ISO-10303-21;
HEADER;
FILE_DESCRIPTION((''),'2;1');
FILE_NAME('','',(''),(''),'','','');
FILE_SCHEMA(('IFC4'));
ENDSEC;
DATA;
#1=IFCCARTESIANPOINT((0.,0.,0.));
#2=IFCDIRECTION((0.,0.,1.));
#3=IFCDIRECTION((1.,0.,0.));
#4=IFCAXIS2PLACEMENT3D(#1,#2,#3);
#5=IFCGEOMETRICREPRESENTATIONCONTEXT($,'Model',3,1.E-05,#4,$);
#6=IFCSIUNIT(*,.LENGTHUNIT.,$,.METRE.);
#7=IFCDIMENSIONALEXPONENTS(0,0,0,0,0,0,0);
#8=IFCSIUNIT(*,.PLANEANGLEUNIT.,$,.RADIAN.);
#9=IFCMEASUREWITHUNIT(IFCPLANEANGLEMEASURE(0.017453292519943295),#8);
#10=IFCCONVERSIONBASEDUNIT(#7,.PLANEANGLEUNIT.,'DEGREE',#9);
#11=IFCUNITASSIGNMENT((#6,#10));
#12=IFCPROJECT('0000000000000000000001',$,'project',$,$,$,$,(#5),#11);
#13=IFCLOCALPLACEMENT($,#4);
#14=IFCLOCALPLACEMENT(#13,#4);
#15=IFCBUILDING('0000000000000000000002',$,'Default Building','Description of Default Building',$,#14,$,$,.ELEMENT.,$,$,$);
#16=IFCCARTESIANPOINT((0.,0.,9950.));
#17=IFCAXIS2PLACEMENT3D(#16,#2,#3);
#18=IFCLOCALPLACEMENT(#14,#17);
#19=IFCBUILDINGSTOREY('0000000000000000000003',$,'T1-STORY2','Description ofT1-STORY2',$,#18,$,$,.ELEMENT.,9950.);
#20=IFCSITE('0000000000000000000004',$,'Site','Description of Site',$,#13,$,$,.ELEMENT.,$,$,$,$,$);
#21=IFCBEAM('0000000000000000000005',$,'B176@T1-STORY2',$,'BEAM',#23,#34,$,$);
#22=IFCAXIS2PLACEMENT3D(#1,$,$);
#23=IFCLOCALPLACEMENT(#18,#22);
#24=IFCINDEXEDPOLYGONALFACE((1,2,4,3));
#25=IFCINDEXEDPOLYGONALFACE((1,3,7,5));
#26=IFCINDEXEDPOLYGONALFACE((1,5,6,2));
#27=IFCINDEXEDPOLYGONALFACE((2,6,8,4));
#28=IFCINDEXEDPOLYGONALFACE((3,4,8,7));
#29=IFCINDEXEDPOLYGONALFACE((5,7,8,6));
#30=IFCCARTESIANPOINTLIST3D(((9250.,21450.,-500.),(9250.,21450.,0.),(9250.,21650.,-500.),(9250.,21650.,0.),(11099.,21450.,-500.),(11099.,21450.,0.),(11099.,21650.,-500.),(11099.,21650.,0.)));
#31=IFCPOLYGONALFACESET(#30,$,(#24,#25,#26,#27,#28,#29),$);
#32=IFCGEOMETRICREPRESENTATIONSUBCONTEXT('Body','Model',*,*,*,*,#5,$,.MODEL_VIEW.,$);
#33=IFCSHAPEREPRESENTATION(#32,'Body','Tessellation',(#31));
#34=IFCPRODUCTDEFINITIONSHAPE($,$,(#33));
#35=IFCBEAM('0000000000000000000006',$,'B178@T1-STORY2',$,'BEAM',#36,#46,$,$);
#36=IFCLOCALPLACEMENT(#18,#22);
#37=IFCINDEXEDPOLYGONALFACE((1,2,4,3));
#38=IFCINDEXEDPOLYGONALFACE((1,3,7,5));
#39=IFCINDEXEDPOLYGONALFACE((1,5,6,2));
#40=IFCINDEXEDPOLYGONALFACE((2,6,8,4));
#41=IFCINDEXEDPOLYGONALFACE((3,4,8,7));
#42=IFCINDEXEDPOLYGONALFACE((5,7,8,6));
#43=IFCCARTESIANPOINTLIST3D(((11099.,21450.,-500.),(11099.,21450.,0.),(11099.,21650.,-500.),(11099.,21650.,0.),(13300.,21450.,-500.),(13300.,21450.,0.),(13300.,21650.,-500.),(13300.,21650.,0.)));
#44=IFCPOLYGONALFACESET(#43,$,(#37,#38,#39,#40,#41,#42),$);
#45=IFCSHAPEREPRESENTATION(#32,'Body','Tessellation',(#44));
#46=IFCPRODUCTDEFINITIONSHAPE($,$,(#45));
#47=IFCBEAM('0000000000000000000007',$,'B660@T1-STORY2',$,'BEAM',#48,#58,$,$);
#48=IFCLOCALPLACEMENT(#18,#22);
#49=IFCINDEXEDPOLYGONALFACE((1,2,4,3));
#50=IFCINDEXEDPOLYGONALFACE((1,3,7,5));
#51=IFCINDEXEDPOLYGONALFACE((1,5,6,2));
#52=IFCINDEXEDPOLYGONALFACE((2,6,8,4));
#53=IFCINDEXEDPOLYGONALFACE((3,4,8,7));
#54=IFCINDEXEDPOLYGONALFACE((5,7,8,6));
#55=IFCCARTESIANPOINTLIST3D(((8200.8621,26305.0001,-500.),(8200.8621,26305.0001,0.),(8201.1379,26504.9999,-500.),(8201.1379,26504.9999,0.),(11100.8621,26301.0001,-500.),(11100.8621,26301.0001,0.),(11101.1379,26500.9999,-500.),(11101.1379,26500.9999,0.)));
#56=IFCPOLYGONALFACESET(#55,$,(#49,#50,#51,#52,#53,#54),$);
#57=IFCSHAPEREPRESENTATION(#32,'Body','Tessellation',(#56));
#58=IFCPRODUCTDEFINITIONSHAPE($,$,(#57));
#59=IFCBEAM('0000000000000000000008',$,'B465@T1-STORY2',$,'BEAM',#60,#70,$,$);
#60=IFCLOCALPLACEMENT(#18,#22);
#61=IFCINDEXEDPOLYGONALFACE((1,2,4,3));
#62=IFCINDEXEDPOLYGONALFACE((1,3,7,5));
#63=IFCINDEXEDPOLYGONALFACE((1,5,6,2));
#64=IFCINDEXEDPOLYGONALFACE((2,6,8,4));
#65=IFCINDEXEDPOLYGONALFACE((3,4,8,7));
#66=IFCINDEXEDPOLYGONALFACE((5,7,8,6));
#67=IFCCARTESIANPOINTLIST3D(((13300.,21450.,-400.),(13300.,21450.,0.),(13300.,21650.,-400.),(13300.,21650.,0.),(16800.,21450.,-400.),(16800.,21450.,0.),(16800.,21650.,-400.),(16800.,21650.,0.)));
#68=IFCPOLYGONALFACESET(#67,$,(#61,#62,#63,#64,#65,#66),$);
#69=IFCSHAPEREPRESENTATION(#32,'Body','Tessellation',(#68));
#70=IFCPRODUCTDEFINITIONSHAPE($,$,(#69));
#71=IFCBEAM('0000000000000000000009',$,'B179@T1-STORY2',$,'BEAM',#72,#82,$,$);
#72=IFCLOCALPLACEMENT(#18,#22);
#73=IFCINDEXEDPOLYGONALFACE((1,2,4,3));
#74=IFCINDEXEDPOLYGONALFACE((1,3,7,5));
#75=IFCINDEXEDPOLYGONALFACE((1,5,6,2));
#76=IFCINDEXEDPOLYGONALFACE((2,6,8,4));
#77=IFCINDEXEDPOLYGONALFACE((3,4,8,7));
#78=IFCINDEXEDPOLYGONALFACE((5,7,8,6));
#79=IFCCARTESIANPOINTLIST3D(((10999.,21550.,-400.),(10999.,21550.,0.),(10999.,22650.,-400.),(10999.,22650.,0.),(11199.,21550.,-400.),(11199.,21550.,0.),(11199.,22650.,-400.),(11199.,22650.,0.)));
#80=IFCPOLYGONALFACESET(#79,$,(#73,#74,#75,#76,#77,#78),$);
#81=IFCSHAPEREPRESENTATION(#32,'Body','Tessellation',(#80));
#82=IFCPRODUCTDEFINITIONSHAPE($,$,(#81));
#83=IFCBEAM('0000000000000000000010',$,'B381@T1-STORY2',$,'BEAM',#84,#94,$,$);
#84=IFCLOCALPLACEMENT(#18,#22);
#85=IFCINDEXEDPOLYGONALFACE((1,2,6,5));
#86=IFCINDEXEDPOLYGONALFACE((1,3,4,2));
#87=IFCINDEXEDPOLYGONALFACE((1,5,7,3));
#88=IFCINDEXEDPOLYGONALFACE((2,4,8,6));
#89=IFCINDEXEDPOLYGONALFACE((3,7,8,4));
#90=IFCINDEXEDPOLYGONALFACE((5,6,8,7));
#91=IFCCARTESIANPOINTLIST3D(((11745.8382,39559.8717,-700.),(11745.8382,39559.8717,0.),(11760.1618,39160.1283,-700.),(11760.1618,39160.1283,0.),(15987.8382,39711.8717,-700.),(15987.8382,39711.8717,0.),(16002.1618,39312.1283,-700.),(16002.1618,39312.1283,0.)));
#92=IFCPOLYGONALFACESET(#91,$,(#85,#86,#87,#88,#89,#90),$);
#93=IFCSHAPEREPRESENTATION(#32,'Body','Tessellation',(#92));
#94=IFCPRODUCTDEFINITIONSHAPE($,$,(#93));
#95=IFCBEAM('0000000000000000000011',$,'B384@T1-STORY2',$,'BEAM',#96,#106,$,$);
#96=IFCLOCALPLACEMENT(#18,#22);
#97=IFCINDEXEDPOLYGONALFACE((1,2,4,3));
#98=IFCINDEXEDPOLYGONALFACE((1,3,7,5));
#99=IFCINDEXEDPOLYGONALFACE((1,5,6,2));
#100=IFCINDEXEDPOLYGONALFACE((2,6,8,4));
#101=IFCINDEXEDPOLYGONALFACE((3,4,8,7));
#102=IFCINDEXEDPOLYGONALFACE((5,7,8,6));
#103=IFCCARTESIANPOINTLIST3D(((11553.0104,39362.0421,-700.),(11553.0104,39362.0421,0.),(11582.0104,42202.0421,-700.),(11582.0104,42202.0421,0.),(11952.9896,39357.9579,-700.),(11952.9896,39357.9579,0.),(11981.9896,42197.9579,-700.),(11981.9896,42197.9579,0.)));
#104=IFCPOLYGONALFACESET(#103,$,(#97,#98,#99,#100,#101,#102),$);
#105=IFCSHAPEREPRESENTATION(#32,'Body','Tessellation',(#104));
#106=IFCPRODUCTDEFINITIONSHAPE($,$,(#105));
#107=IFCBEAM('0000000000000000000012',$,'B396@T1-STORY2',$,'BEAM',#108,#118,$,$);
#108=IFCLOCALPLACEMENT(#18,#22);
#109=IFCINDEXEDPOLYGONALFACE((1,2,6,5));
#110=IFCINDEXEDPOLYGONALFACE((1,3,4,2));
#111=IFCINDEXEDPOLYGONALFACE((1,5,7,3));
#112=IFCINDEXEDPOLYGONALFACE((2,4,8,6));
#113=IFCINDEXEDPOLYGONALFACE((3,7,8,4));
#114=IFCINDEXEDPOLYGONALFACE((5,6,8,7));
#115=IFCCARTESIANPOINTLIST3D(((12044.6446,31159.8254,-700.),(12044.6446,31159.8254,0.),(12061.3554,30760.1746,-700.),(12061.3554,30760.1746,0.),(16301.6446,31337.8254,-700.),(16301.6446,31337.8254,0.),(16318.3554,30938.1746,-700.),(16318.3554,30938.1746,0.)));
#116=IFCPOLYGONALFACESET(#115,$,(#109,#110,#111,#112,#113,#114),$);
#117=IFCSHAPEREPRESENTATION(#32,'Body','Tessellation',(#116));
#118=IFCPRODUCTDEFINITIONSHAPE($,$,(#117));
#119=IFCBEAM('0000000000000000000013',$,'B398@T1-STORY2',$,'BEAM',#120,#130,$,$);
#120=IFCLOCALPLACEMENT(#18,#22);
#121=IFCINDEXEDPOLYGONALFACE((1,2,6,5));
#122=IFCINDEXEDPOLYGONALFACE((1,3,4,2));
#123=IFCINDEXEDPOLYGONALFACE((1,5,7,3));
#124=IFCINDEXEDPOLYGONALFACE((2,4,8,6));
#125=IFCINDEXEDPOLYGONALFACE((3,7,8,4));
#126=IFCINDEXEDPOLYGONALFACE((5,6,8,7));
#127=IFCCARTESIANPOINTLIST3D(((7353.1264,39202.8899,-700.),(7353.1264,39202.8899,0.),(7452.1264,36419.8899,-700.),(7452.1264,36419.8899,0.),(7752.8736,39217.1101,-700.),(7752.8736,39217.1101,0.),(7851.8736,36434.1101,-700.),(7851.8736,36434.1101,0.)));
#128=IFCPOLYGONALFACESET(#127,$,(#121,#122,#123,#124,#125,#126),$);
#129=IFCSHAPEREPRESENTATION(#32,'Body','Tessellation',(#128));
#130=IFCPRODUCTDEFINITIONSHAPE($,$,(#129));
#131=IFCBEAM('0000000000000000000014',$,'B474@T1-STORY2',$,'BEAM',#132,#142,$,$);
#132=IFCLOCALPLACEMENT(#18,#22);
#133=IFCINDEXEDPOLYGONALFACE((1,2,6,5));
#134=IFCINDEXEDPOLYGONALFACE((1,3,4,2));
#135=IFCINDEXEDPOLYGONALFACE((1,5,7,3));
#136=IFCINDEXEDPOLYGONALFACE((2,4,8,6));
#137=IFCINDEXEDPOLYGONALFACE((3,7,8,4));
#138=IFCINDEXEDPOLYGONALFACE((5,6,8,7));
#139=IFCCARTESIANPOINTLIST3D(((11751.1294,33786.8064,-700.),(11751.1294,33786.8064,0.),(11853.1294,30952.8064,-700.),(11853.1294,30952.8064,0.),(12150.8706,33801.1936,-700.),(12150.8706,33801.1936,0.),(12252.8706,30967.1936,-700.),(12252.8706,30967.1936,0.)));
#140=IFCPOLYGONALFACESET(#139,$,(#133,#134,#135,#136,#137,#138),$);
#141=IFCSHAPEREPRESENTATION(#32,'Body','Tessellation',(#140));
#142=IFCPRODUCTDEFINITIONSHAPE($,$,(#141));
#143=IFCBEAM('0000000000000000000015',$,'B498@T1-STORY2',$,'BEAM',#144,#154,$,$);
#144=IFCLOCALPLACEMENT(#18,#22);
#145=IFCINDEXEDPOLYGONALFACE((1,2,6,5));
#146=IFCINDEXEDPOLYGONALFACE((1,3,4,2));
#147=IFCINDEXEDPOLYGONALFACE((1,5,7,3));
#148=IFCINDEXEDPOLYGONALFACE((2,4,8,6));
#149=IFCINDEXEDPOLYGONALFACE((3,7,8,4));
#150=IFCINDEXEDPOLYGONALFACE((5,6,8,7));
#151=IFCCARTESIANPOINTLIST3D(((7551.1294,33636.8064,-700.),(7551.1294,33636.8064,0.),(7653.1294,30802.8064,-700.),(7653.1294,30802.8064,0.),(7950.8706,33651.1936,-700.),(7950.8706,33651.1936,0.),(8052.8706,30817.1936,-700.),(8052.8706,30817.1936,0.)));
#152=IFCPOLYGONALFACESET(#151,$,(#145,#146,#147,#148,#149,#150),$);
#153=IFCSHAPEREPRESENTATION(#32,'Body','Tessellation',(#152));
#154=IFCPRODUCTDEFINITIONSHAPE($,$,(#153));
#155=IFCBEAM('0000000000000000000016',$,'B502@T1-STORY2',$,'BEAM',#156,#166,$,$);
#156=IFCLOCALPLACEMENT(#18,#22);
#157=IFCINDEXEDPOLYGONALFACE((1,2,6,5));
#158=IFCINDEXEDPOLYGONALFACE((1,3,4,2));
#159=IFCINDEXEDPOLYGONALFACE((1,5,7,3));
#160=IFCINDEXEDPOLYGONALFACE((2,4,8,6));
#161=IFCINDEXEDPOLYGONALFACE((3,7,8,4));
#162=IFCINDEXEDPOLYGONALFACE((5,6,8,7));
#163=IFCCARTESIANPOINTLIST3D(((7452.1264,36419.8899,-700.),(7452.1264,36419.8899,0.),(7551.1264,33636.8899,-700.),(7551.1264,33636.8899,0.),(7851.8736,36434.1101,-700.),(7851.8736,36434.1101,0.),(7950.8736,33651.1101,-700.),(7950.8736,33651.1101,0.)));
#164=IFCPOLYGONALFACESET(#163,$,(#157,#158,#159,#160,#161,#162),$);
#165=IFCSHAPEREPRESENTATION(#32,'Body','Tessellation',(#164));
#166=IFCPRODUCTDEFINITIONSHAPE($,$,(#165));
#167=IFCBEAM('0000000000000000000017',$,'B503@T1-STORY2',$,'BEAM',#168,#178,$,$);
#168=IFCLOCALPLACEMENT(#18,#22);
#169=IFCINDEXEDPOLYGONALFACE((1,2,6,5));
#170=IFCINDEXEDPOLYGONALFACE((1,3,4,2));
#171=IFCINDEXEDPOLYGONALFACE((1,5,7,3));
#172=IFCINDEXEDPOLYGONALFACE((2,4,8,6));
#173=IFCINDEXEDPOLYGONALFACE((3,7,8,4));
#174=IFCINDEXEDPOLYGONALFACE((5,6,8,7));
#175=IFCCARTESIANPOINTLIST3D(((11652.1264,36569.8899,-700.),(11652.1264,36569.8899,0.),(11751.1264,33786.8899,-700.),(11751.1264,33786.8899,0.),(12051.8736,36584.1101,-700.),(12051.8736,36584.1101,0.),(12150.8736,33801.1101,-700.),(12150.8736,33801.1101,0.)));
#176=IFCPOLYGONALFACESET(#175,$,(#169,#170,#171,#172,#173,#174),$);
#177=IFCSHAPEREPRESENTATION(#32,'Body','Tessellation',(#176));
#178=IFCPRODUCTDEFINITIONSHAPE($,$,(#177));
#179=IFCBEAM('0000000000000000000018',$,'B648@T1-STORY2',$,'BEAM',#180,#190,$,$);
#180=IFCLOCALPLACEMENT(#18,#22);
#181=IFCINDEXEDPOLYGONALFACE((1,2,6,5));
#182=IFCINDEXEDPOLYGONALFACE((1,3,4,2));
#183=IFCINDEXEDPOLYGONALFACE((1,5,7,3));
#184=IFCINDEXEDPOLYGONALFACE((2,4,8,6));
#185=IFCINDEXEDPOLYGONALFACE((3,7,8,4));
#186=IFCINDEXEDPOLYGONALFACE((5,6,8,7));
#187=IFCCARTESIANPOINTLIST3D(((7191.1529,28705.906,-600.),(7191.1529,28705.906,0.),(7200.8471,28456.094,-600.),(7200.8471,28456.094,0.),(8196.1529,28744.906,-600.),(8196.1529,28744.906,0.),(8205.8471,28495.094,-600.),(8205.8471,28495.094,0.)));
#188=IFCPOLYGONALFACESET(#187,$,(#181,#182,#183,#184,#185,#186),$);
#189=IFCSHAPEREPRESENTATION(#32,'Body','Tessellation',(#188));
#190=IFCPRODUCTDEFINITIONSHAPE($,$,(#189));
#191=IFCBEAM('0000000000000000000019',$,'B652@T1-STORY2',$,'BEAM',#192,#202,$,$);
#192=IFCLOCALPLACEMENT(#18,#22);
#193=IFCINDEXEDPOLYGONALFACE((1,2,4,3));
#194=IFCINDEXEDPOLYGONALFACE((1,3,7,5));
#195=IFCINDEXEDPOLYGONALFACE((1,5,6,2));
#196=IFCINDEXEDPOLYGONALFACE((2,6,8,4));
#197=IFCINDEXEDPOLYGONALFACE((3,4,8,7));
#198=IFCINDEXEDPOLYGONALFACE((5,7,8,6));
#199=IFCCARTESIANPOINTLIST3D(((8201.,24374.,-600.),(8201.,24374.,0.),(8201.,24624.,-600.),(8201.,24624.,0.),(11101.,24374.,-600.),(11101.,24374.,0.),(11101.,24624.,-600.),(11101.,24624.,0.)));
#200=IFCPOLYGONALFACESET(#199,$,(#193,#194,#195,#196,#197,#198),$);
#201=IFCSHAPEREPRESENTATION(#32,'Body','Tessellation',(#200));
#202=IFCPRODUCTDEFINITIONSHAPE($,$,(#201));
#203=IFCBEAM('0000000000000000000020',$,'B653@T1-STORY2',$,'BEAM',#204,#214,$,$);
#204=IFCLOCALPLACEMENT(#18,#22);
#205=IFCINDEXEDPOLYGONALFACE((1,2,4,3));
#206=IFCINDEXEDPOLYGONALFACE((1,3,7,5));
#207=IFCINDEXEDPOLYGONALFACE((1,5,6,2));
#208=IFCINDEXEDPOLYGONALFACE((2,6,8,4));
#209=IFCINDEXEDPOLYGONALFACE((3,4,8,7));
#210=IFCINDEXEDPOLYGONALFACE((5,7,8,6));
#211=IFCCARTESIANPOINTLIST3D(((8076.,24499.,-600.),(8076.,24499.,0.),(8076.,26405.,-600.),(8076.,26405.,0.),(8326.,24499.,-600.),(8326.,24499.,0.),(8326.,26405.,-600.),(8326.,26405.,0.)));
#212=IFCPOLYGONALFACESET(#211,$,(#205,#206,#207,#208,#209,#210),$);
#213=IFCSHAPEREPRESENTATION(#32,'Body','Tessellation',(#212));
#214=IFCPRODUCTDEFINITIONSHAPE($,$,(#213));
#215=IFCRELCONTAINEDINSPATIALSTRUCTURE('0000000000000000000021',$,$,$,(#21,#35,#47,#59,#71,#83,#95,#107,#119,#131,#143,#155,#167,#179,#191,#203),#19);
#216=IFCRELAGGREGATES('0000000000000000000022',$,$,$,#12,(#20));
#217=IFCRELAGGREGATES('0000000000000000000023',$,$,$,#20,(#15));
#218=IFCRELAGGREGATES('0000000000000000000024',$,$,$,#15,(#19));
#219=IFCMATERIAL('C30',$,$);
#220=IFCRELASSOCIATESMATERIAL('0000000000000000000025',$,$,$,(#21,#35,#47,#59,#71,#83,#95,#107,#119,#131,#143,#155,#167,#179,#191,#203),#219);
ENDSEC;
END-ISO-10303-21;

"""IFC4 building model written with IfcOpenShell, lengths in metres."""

from ifc_helpers import new_model, entity, si_unit, converted_unit, frame, origin_with_axes, place, context, subcontext, project, spatial, rectangle, extrude, material, element, save


model = new_model("IFC4")

# Units and contexts
model_context = context("Model", 3, precision=1e-05, world=origin_with_axes())
body_context = subcontext(model_context, "Body", "Model", "MODEL_VIEW")
ifc_project = project(units=[si_unit("LENGTHUNIT", "METRE"), converted_unit("PLANEANGLEUNIT", "DEGREE", entity("IfcPlaneAngleMeasure", 0.017453292519943295), si_unit("PLANEANGLEUNIT", "RADIAN"), dimensions=[0, 0, 0, 0, 0, 0, 0])], contexts=[model_context])

# Site, building, storey
site_placement = place(None, origin_with_axes())
site = spatial("IfcSite", under=ifc_project, at=site_placement, Name="Site", Description="Description of Site", CompositionType="ELEMENT")
building_placement = place(site_placement, origin_with_axes())
building = spatial("IfcBuilding", under=site, at=building_placement, Name="Default Building", Description="Description of Default Building", CompositionType="ELEMENT")
storey_placement = place(building_placement, frame((0.0, 0.0, 9950.0), z_axis=(0.0, 0.0, 1.0), x_axis=(1.0, 0.0, 0.0)))
storey = spatial("IfcBuildingStorey", under=building, at=storey_placement, Name="T1-STORY2", Description="Description ofT1-STORY2", CompositionType="ELEMENT", Elevation=9950.0)

# Beams
ifc_material_1 = material(Name="C30")
beam_1_placement = place(storey_placement, frame((9250.0, 21550.0, -250.0), z_axis=(1.0, 0.0, 0.0), x_axis=(0.0, 1.0, 0.0)))
element("IfcBeam", 1, at=beam_1_placement, inside=storey, material=ifc_material_1, Name="B176@T1-STORY2", ObjectType="BEAM", context=body_context, shape_type="SweptSolid", body=[
    extrude(rectangle(XDim=200.0, YDim=500.0), origin_with_axes(), (0.0, 0.0, 1.0), 1849.0),
])
beam_2_placement = place(storey_placement, frame((11099.0, 21550.0, -250.0), z_axis=(1.0, 0.0, 0.0), x_axis=(0.0, 1.0, 0.0)))
element("IfcBeam", 2, at=beam_2_placement, inside=storey, material=ifc_material_1, Name="B178@T1-STORY2", ObjectType="BEAM", context=body_context, shape_type="SweptSolid", body=[
    extrude(rectangle(XDim=200.0, YDim=500.0), origin_with_axes(), (0.0, 0.0, 1.0), 2201.0),
])
beam_3_placement = place(storey_placement, frame((8201.0, 26405.0, -250.0), z_axis=(0.999999, -0.001379, 0.0), x_axis=(0.001379, 0.999999, 0.0)))
element("IfcBeam", 3, at=beam_3_placement, inside=storey, material=ifc_material_1, Name="B660@T1-STORY2", ObjectType="BEAM", context=body_context, shape_type="SweptSolid", body=[
    extrude(rectangle(XDim=200.0, YDim=500.0), origin_with_axes(), (0.0, 0.0, 1.0), 2900.0028),
])
beam_4_placement = place(storey_placement, frame((13300.0, 21550.0, -200.0), z_axis=(1.0, 0.0, 0.0), x_axis=(0.0, 1.0, 0.0)))
element("IfcBeam", 4, at=beam_4_placement, inside=storey, material=ifc_material_1, Name="B465@T1-STORY2", ObjectType="BEAM", context=body_context, shape_type="SweptSolid", body=[
    extrude(rectangle(XDim=200.0, YDim=400.0), origin_with_axes(), (0.0, 0.0, 1.0), 3500.0),
])
beam_5_placement = place(storey_placement, frame((11099.0, 21550.0, -200.0), z_axis=(0.0, 1.0, 0.0), x_axis=(-1.0, 0.0, 0.0)))
element("IfcBeam", 5, at=beam_5_placement, inside=storey, material=ifc_material_1, Name="B179@T1-STORY2", ObjectType="BEAM", context=body_context, shape_type="SweptSolid", body=[
    extrude(rectangle(XDim=200.0, YDim=400.0), origin_with_axes(), (0.0, 0.0, 1.0), 1100.0),
])
beam_6_placement = place(storey_placement, frame((11753.0, 39360.0, -350.0), z_axis=(0.999359, 0.035809, 0.0), x_axis=(-0.035809, 0.999359, 0.0)))
element("IfcBeam", 6, at=beam_6_placement, inside=storey, material=ifc_material_1, Name="B381@T1-STORY2", ObjectType="BEAM", context=body_context, shape_type="SweptSolid", body=[
    extrude(rectangle(XDim=400.0, YDim=700.0), origin_with_axes(), (0.0, 0.0, 1.0), 4244.7224),
])
beam_7_placement = place(storey_placement, frame((11753.0, 39360.0, -350.0), z_axis=(0.010211, 0.999948, 0.0), x_axis=(-0.999948, 0.010211, 0.0)))
element("IfcBeam", 7, at=beam_7_placement, inside=storey, material=ifc_material_1, Name="B384@T1-STORY2", ObjectType="BEAM", context=body_context, shape_type="SweptSolid", body=[
    extrude(rectangle(XDim=400.0, YDim=700.0), origin_with_axes(), (0.0, 0.0, 1.0), 2840.1481),
])
beam_8_placement = place(storey_placement, frame((12053.0, 30960.0, -350.0), z_axis=(0.999127, 0.041777, 0.0), x_axis=(-0.041777, 0.999127, 0.0)))
element("IfcBeam", 8, at=beam_8_placement, inside=storey, material=ifc_material_1, Name="B396@T1-STORY2", ObjectType="BEAM", context=body_context, shape_type="SweptSolid", body=[
    extrude(rectangle(XDim=400.0, YDim=700.0), origin_with_axes(), (0.0, 0.0, 1.0), 4260.7198),
])
beam_9_placement = place(storey_placement, frame((7553.0, 39210.0, -350.0), z_axis=(0.035551, -0.999368, 0.0), x_axis=(0.999368, 0.035551, 0.0)))
element("IfcBeam", 9, at=beam_9_placement, inside=storey, material=ifc_material_1, Name="B398@T1-STORY2", ObjectType="BEAM", context=body_context, shape_type="SweptSolid", body=[
    extrude(rectangle(XDim=400.0, YDim=700.0), origin_with_axes(), (0.0, 0.0, 1.0), 2784.7603),
])
for number, where, z_axis, x_axis, name in (
    (10, (11951.0, 33794.0, -350.0), (0.035968, -0.999353, 0.0), (0.999353, 0.035968, 0.0), "B474@T1-STORY2"),
    (11, (7751.0, 33644.0, -350.0), (0.035968, -0.999353, 0.0), (0.999353, 0.035968, 0.0), "B498@T1-STORY2"),
):
    element("IfcBeam", number, at=place(storey_placement, frame(where, z_axis=z_axis, x_axis=x_axis)), inside=storey, material=ifc_material_1, Name=name, ObjectType="BEAM", context=body_context, shape_type="SweptSolid", body=[
        extrude(rectangle(XDim=400.0, YDim=700.0), origin_with_axes(), (0.0, 0.0, 1.0), 2835.835),
    ])
for number, where, z_axis, x_axis, name in (
    (12, (7652.0, 36427.0, -350.0), (0.035551, -0.999368, 0.0), (0.999368, 0.035551, 0.0), "B502@T1-STORY2"),
    (13, (11852.0, 36577.0, -350.0), (0.035551, -0.999368, 0.0), (0.999368, 0.035551, 0.0), "B503@T1-STORY2"),
):
    element("IfcBeam", number, at=place(storey_placement, frame(where, z_axis=z_axis, x_axis=x_axis)), inside=storey, material=ifc_material_1, Name=name, ObjectType="BEAM", context=body_context, shape_type="SweptSolid", body=[
        extrude(rectangle(XDim=400.0, YDim=700.0), origin_with_axes(), (0.0, 0.0, 1.0), 2784.7603),
    ])
beam_10_placement = place(storey_placement, frame((7196.0, 28581.0, -300.0), z_axis=(0.999248, 0.038777, 0.0), x_axis=(-0.038777, 0.999248, 0.0)))
element("IfcBeam", 14, at=beam_10_placement, inside=storey, material=ifc_material_1, Name="B648@T1-STORY2", ObjectType="BEAM", context=body_context, shape_type="SweptSolid", body=[
    extrude(rectangle(XDim=250.0, YDim=600.0), origin_with_axes(), (0.0, 0.0, 1.0), 1005.7564),
])
beam_11_placement = place(storey_placement, frame((8201.0, 24499.0, -300.0), z_axis=(1.0, 0.0, 0.0), x_axis=(0.0, 1.0, 0.0)))
element("IfcBeam", 15, at=beam_11_placement, inside=storey, material=ifc_material_1, Name="B652@T1-STORY2", ObjectType="BEAM", context=body_context, shape_type="SweptSolid", body=[
    extrude(rectangle(XDim=250.0, YDim=600.0), origin_with_axes(), (0.0, 0.0, 1.0), 2900.0),
])
beam_12_placement = place(storey_placement, frame((8201.0, 24499.0, -300.0), z_axis=(0.0, 1.0, 0.0), x_axis=(-1.0, 0.0, 0.0)))
element("IfcBeam", 16, at=beam_12_placement, inside=storey, material=ifc_material_1, Name="B653@T1-STORY2", ObjectType="BEAM", context=body_context, shape_type="SweptSolid", body=[
    extrude(rectangle(XDim=250.0, YDim=600.0), origin_with_axes(), (0.0, 0.0, 1.0), 1906.0),
])

save(model, "model.ifc")
